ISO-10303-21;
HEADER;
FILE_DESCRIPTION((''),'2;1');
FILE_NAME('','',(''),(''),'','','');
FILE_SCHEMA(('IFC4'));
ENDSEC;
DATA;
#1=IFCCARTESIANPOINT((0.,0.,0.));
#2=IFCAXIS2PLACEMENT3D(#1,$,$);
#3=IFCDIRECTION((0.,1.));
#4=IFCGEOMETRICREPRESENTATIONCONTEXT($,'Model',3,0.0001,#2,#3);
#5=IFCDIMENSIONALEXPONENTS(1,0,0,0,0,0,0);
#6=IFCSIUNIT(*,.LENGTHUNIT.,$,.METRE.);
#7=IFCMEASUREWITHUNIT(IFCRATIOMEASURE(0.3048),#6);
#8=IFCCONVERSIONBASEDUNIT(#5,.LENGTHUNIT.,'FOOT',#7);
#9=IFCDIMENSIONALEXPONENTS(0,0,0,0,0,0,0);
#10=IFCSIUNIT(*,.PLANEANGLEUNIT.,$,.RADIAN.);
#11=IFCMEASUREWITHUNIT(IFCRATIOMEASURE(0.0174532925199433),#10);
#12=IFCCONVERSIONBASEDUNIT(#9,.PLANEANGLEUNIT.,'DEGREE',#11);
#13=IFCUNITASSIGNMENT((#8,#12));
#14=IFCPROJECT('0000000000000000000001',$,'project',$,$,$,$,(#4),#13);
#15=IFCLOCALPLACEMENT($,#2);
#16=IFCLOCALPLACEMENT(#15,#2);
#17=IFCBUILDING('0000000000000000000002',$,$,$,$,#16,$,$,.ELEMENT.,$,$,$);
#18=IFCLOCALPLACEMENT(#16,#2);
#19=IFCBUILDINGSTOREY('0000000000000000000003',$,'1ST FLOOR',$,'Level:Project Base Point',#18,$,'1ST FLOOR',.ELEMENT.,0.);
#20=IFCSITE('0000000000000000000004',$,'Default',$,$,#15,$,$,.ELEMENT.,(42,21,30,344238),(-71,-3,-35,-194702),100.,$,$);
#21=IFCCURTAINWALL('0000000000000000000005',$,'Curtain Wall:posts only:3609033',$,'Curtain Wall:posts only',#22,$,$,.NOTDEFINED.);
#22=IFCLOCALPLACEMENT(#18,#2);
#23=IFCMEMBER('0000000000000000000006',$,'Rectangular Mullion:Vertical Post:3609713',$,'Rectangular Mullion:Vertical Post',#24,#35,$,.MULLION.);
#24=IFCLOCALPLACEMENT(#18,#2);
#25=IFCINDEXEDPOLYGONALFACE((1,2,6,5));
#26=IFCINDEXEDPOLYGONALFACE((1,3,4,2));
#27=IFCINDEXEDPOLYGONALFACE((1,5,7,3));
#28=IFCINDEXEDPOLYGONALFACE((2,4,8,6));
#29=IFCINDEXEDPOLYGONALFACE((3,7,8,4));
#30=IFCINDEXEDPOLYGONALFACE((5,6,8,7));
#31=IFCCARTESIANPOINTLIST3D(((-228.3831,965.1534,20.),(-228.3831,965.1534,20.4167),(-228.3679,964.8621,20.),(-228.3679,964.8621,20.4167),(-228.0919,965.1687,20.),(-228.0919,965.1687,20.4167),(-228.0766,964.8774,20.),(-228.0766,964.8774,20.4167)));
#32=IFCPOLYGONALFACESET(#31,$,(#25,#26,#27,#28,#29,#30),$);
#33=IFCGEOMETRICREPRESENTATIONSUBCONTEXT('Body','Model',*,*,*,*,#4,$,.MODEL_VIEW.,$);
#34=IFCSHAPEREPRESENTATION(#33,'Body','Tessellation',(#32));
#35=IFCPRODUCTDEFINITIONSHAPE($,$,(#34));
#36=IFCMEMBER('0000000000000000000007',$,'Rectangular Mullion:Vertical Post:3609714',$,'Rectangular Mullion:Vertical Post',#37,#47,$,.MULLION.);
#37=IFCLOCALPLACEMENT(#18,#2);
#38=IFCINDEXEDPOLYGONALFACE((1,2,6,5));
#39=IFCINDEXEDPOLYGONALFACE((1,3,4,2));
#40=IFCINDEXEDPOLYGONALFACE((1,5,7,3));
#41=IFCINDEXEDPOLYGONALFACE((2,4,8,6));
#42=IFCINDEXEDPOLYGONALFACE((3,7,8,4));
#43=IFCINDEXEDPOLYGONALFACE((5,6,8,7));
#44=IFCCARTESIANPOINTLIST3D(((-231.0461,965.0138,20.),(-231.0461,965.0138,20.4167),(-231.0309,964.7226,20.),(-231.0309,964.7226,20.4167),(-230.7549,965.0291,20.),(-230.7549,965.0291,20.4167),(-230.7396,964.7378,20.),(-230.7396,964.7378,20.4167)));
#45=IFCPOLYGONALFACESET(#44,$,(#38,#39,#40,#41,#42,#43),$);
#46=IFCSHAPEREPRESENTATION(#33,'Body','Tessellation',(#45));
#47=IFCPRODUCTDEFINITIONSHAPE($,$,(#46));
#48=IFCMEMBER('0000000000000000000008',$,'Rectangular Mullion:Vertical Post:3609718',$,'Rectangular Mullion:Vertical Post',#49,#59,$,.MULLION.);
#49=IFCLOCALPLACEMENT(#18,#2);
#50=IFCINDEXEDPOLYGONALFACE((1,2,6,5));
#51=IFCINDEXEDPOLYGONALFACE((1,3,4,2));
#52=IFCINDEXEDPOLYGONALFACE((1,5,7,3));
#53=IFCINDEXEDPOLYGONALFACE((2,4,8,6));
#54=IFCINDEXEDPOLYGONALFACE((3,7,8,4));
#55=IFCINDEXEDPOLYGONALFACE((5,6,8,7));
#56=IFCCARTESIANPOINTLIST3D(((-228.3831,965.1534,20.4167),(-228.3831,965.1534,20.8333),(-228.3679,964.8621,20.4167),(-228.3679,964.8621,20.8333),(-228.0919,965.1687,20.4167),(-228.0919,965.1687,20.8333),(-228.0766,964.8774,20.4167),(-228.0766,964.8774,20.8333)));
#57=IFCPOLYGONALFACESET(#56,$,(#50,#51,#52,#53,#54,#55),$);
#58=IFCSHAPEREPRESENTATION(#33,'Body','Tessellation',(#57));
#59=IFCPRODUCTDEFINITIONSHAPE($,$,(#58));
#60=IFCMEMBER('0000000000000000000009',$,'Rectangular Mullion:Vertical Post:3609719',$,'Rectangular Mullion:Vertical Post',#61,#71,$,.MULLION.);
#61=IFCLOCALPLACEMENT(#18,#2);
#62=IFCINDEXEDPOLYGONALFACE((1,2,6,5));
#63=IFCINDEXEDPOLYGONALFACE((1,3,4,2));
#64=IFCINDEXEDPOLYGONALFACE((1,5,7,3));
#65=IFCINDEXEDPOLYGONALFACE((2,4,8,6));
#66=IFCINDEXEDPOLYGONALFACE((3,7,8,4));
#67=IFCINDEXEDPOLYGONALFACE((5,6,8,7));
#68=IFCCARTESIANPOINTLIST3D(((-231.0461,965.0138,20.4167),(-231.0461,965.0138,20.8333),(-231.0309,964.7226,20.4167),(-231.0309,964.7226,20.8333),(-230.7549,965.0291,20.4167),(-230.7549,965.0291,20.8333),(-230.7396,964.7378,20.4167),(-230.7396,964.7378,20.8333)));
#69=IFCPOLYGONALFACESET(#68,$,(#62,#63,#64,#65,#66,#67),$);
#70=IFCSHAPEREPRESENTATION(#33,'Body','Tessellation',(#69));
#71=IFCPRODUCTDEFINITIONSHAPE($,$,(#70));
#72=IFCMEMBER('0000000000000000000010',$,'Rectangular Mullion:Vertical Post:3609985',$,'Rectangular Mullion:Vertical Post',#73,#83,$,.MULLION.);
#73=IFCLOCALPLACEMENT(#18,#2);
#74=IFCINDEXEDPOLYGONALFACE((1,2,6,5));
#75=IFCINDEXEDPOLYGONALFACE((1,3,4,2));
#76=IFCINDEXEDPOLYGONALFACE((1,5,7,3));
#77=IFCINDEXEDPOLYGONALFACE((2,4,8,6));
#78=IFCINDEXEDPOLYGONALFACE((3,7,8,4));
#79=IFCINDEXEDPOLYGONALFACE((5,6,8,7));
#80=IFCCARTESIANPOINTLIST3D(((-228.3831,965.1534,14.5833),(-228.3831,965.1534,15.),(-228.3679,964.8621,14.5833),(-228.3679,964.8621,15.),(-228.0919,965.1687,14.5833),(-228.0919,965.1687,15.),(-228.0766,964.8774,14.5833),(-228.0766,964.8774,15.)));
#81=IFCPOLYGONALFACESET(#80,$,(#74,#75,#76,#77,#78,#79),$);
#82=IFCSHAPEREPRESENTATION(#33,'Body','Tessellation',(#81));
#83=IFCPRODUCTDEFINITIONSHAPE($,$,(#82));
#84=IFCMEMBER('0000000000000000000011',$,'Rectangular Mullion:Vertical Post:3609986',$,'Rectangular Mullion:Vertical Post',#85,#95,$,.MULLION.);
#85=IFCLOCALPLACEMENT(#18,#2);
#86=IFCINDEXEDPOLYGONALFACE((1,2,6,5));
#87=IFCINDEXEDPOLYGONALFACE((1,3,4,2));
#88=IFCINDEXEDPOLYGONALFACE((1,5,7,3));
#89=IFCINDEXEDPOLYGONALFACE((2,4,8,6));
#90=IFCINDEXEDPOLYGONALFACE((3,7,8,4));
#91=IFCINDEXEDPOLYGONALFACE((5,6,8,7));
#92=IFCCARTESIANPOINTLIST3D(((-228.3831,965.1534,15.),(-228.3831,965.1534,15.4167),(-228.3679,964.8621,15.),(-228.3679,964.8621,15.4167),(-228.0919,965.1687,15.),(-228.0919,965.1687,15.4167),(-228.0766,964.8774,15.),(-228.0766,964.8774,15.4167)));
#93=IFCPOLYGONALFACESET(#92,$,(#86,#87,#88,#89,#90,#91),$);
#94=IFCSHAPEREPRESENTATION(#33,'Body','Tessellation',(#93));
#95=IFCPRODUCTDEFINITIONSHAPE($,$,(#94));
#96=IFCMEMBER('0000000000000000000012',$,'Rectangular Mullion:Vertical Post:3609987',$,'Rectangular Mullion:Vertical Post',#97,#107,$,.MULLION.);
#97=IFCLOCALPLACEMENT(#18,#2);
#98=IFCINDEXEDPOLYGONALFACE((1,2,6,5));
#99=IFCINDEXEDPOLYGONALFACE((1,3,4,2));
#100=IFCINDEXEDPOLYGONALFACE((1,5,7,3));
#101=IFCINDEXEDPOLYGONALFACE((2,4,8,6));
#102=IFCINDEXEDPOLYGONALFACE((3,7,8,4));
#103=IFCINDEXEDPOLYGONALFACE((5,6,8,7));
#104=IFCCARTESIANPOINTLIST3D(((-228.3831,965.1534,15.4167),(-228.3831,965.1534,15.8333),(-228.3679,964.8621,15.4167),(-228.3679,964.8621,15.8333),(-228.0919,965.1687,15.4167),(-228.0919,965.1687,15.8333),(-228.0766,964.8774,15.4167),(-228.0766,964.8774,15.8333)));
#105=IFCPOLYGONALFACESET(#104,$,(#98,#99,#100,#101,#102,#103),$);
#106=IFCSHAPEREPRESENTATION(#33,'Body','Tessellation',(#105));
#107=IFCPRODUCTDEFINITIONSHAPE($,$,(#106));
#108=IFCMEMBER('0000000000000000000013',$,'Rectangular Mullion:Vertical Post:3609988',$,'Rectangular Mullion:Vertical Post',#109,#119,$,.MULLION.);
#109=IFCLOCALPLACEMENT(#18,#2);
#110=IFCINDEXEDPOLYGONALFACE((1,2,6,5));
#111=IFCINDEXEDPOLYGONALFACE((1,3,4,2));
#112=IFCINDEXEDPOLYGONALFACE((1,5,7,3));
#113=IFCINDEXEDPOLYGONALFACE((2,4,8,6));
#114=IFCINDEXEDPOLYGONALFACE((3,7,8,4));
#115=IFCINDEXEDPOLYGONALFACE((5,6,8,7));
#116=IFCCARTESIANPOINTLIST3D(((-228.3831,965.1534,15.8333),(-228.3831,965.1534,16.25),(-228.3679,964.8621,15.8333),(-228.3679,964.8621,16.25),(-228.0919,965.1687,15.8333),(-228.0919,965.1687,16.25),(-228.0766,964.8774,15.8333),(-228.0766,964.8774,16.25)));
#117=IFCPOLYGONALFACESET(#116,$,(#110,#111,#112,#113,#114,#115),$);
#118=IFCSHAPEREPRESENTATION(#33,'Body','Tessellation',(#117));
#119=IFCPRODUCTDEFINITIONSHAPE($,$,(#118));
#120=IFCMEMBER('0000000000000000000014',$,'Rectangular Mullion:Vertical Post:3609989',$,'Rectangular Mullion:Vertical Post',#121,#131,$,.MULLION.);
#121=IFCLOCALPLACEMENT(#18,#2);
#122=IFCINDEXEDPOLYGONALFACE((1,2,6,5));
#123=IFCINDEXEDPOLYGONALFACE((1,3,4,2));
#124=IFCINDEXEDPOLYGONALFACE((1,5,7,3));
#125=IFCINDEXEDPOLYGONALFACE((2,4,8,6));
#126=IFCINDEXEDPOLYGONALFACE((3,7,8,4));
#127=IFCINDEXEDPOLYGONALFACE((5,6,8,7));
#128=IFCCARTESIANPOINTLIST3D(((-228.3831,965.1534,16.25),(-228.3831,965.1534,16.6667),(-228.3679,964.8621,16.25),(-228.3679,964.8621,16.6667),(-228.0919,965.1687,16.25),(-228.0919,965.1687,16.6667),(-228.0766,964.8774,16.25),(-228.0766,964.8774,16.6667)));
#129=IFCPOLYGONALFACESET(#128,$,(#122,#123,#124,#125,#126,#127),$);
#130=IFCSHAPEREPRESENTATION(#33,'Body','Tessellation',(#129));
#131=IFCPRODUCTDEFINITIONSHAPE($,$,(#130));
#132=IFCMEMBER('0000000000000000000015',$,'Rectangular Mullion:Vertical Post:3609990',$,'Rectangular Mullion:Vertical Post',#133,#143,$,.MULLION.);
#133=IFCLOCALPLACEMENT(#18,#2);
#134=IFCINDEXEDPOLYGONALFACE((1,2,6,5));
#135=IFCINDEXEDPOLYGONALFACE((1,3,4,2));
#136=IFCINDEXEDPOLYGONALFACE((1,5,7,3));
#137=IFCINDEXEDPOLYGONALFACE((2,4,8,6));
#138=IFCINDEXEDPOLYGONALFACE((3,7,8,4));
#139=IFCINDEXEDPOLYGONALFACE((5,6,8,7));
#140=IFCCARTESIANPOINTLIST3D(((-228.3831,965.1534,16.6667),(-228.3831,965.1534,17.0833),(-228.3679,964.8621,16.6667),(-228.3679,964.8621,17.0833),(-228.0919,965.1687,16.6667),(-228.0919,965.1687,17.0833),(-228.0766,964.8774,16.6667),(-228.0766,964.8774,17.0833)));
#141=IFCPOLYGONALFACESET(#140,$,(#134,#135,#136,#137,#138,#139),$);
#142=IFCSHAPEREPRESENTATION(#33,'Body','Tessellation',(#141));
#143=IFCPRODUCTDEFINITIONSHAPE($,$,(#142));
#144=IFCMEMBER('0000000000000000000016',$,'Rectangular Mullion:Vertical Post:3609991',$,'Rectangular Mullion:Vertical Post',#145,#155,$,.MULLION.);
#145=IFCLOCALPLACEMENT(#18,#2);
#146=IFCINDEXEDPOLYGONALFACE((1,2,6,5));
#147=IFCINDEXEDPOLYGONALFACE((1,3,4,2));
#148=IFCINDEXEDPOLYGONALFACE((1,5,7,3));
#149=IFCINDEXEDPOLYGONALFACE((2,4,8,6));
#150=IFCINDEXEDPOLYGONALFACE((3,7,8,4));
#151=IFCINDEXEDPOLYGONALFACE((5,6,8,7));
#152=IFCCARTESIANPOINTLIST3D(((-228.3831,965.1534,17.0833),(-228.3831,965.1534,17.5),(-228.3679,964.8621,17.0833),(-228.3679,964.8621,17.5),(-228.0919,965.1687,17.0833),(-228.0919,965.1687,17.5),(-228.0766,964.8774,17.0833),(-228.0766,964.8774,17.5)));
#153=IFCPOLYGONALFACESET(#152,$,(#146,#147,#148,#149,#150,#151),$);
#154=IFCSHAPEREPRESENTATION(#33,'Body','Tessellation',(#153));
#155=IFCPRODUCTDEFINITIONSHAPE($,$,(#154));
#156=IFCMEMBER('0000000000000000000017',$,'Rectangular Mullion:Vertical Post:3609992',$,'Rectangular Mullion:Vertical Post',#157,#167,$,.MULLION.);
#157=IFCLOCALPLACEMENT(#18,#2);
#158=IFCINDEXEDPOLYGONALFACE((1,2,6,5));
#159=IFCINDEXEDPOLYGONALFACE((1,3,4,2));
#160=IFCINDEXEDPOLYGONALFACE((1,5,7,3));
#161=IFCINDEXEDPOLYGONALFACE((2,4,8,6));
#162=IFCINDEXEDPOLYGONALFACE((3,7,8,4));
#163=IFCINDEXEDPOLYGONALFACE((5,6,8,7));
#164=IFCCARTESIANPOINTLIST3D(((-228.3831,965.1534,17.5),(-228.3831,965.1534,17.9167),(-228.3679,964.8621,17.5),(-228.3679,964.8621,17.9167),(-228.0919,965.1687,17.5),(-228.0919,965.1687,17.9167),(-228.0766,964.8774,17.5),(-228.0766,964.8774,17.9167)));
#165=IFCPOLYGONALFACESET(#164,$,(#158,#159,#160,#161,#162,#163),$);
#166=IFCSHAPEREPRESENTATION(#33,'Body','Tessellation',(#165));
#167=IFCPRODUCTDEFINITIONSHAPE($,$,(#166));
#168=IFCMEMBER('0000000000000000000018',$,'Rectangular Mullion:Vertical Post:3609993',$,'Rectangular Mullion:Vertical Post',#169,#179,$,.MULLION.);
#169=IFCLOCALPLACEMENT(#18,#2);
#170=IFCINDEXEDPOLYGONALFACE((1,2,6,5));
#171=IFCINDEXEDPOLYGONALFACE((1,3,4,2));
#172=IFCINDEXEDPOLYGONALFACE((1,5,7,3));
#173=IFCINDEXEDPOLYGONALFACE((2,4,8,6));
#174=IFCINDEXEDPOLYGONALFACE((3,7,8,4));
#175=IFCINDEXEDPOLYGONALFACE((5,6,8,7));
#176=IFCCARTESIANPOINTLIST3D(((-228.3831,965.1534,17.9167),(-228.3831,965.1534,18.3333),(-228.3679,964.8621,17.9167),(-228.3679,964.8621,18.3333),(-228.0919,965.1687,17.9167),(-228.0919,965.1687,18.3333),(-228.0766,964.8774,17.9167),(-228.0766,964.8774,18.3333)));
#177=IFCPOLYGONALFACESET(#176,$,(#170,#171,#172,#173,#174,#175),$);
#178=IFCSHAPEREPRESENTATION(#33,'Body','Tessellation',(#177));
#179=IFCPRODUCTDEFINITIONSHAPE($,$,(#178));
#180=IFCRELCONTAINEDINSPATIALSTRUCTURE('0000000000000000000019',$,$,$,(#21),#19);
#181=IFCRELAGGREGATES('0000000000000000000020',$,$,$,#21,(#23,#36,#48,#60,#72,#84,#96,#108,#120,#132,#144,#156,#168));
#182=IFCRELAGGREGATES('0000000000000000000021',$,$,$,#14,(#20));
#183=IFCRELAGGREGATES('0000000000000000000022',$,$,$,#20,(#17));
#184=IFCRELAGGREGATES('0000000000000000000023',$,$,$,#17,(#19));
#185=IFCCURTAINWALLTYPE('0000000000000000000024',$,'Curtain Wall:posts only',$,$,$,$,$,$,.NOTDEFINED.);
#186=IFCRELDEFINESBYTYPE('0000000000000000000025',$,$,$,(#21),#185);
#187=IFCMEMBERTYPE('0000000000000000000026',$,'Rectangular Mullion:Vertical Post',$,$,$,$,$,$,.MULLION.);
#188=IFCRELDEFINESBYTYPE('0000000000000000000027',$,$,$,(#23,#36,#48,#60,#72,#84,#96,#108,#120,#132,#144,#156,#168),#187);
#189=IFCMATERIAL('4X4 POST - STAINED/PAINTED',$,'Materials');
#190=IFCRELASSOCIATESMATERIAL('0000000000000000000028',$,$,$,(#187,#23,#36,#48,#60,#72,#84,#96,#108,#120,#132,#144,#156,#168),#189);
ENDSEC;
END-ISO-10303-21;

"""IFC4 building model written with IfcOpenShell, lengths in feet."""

from ifc_helpers import new_model, entity, si_unit, converted_unit, direction, frame, origin, origin_2d_with_axis, place, context, subcontext, project, spatial, rectangle, extrude, source, transform, mapped, material, material_profile, profile_set, profile_usage, type_object, type_shapes, element, aggregate, save


model = new_model("IFC4")

# Units and contexts
model_context = context("Model", 3, precision=0.0001, world=origin(), true_north=direction((0.0, 1.0)))
body_context = subcontext(model_context, "Body", "Model", "MODEL_VIEW")
ifc_project = project(units=[converted_unit("LENGTHUNIT", "FOOT", entity("IfcRatioMeasure", 0.3048), si_unit("LENGTHUNIT", "METRE"), dimensions=[1, 0, 0, 0, 0, 0, 0]), converted_unit("PLANEANGLEUNIT", "DEGREE", entity("IfcRatioMeasure", 0.0174532925199433), si_unit("PLANEANGLEUNIT", "RADIAN"), dimensions=[0, 0, 0, 0, 0, 0, 0])], contexts=[model_context])

# Site, building, storey
site_placement = place(None, origin())
site = spatial("IfcSite", under=ifc_project, at=site_placement, Name="Default", CompositionType="ELEMENT", RefLatitude=(42, 21, 30, 344238), RefLongitude=(-71, -3, -35, -194702), RefElevation=100.0)
building_placement = place(site_placement, origin())
building = spatial("IfcBuilding", under=site, at=building_placement, CompositionType="ELEMENT")
storey_placement = place(building_placement, origin())
storey = spatial("IfcBuildingStorey", under=building, at=storey_placement, Name="1ST FLOOR", ObjectType="Level:Project Base Point", LongName="1ST FLOOR", CompositionType="ELEMENT", Elevation=0.0)

# Curtain wall, members
curtain_wall_type_1 = type_object("IfcCurtainWallType", Name="Curtain Wall:posts only", PredefinedType="NOTDEFINED")
curtain_wall_1_placement = place(storey_placement, origin())
curtain_wall_1 = element("IfcCurtainWall", 1, at=curtain_wall_1_placement, inside=storey, type_object=curtain_wall_type_1, Name="Curtain Wall:posts only:3609033", ObjectType="Curtain Wall:posts only", PredefinedType="NOTDEFINED")
ifc_material_1 = material(Name="4X4 POST - STAINED/PAINTED", Category="Materials")
ifc_material_profile_1 = material_profile(ifc_material_1, rectangle(XDim=0.2917, YDim=0.2917, at=origin_2d_with_axis()), Name="Vertical Post")
ifc_profile_set_1 = profile_set([ifc_material_profile_1], Name="Vertical Post")
ifc_profile_usage_1 = profile_usage(ifc_profile_set_1)
member_type_1 = type_object("IfcMemberType", Name="Rectangular Mullion:Vertical Post", PredefinedType="MULLION", material=ifc_profile_set_1)
shared_shape_1 = source(origin(), body_context, "Body", "SweptSolid", [
    extrude(rectangle(XDim=0.2917, YDim=0.2917, at=origin_2d_with_axis()), frame((0.0, -0.2083, -0.4167), z_axis=(0.0, 0.0, 1.0), x_axis=(0.0, -1.0, 0.0)), (0.0, 0.0, 1.0), 0.4167),
])
type_shapes(member_type_1, [shared_shape_1])
member_1_placement = place(storey_placement, frame((-228.2408, 965.2235, 20.0), z_axis=(0.0, 0.0, -1.0), x_axis=(-0.99863, -0.052336, 0.0)))
member_1 = element("IfcMember", 2, at=member_1_placement, type_object=member_type_1, material=ifc_profile_usage_1, Name="Rectangular Mullion:Vertical Post:3609713", ObjectType="Rectangular Mullion:Vertical Post", PredefinedType="MULLION", context=body_context, shape_type="MappedRepresentation", body=[
    mapped(shared_shape_1, transform((0.0, 0.0, 0.0), scale=1.0)),
])
ifc_profile_usage_2 = profile_usage(ifc_profile_set_1)
member_2_placement = place(storey_placement, frame((-230.9038, 965.0839, 20.0), z_axis=(0.0, 0.0, -1.0), x_axis=(-0.99863, -0.052336, 0.0)))
member_2 = element("IfcMember", 3, at=member_2_placement, type_object=member_type_1, material=ifc_profile_usage_2, Name="Rectangular Mullion:Vertical Post:3609714", ObjectType="Rectangular Mullion:Vertical Post", PredefinedType="MULLION", context=body_context, shape_type="MappedRepresentation", body=[
    mapped(shared_shape_1, transform((0.0, 0.0, 0.0), scale=1.0)),
])
ifc_profile_usage_3 = profile_usage(ifc_profile_set_1)
member_3_placement = place(storey_placement, frame((-228.2408, 965.2235, 20.4167), z_axis=(0.0, 0.0, -1.0), x_axis=(-0.99863, -0.052336, 0.0)))
member_3 = element("IfcMember", 4, at=member_3_placement, type_object=member_type_1, material=ifc_profile_usage_3, Name="Rectangular Mullion:Vertical Post:3609718", ObjectType="Rectangular Mullion:Vertical Post", PredefinedType="MULLION", context=body_context, shape_type="MappedRepresentation", body=[
    mapped(shared_shape_1, transform((0.0, 0.0, 0.0), scale=1.0)),
])
ifc_profile_usage_4 = profile_usage(ifc_profile_set_1)
member_4_placement = place(storey_placement, frame((-230.9038, 965.0839, 20.4167), z_axis=(0.0, 0.0, -1.0), x_axis=(-0.99863, -0.052336, 0.0)))
member_4 = element("IfcMember", 5, at=member_4_placement, type_object=member_type_1, material=ifc_profile_usage_4, Name="Rectangular Mullion:Vertical Post:3609719", ObjectType="Rectangular Mullion:Vertical Post", PredefinedType="MULLION", context=body_context, shape_type="MappedRepresentation", body=[
    mapped(shared_shape_1, transform((0.0, 0.0, 0.0), scale=1.0)),
])
ifc_profile_usage_5 = profile_usage(ifc_profile_set_1)
member_5_placement = place(storey_placement, frame((-228.2408, 965.2235, 14.5833), z_axis=(0.0, 0.0, -1.0), x_axis=(-0.99863, -0.052336, 0.0)))
member_5 = element("IfcMember", 6, at=member_5_placement, type_object=member_type_1, material=ifc_profile_usage_5, Name="Rectangular Mullion:Vertical Post:3609985", ObjectType="Rectangular Mullion:Vertical Post", PredefinedType="MULLION", context=body_context, shape_type="MappedRepresentation", body=[
    mapped(shared_shape_1, transform((0.0, 0.0, 0.0), scale=1.0)),
])
ifc_profile_usage_6 = profile_usage(ifc_profile_set_1)
member_6_placement = place(storey_placement, frame((-228.2408, 965.2235, 15.0), z_axis=(0.0, 0.0, -1.0), x_axis=(-0.99863, -0.052336, 0.0)))
member_6 = element("IfcMember", 7, at=member_6_placement, type_object=member_type_1, material=ifc_profile_usage_6, Name="Rectangular Mullion:Vertical Post:3609986", ObjectType="Rectangular Mullion:Vertical Post", PredefinedType="MULLION", context=body_context, shape_type="MappedRepresentation", body=[
    mapped(shared_shape_1, transform((0.0, 0.0, 0.0), scale=1.0)),
])
ifc_profile_usage_7 = profile_usage(ifc_profile_set_1)
member_7_placement = place(storey_placement, frame((-228.2408, 965.2235, 15.4167), z_axis=(0.0, 0.0, -1.0), x_axis=(-0.99863, -0.052336, 0.0)))
member_7 = element("IfcMember", 8, at=member_7_placement, type_object=member_type_1, material=ifc_profile_usage_7, Name="Rectangular Mullion:Vertical Post:3609987", ObjectType="Rectangular Mullion:Vertical Post", PredefinedType="MULLION", context=body_context, shape_type="MappedRepresentation", body=[
    mapped(shared_shape_1, transform((0.0, 0.0, 0.0), scale=1.0)),
])
ifc_profile_usage_8 = profile_usage(ifc_profile_set_1)
member_8_placement = place(storey_placement, frame((-228.2408, 965.2235, 15.8333), z_axis=(0.0, 0.0, -1.0), x_axis=(-0.99863, -0.052336, 0.0)))
member_8 = element("IfcMember", 9, at=member_8_placement, type_object=member_type_1, material=ifc_profile_usage_8, Name="Rectangular Mullion:Vertical Post:3609988", ObjectType="Rectangular Mullion:Vertical Post", PredefinedType="MULLION", context=body_context, shape_type="MappedRepresentation", body=[
    mapped(shared_shape_1, transform((0.0, 0.0, 0.0), scale=1.0)),
])
ifc_profile_usage_9 = profile_usage(ifc_profile_set_1)
member_9_placement = place(storey_placement, frame((-228.2408, 965.2235, 16.25), z_axis=(0.0, 0.0, -1.0), x_axis=(-0.99863, -0.052336, 0.0)))
member_9 = element("IfcMember", 10, at=member_9_placement, type_object=member_type_1, material=ifc_profile_usage_9, Name="Rectangular Mullion:Vertical Post:3609989", ObjectType="Rectangular Mullion:Vertical Post", PredefinedType="MULLION", context=body_context, shape_type="MappedRepresentation", body=[
    mapped(shared_shape_1, transform((0.0, 0.0, 0.0), scale=1.0)),
])
ifc_profile_usage_10 = profile_usage(ifc_profile_set_1)
member_10_placement = place(storey_placement, frame((-228.2408, 965.2235, 16.6667), z_axis=(0.0, 0.0, -1.0), x_axis=(-0.99863, -0.052336, 0.0)))
member_10 = element("IfcMember", 11, at=member_10_placement, type_object=member_type_1, material=ifc_profile_usage_10, Name="Rectangular Mullion:Vertical Post:3609990", ObjectType="Rectangular Mullion:Vertical Post", PredefinedType="MULLION", context=body_context, shape_type="MappedRepresentation", body=[
    mapped(shared_shape_1, transform((0.0, 0.0, 0.0), scale=1.0)),
])
ifc_profile_usage_11 = profile_usage(ifc_profile_set_1)
member_11_placement = place(storey_placement, frame((-228.2408, 965.2235, 17.0833), z_axis=(0.0, 0.0, -1.0), x_axis=(-0.99863, -0.052336, 0.0)))
member_11 = element("IfcMember", 12, at=member_11_placement, type_object=member_type_1, material=ifc_profile_usage_11, Name="Rectangular Mullion:Vertical Post:3609991", ObjectType="Rectangular Mullion:Vertical Post", PredefinedType="MULLION", context=body_context, shape_type="MappedRepresentation", body=[
    mapped(shared_shape_1, transform((0.0, 0.0, 0.0), scale=1.0)),
])
ifc_profile_usage_12 = profile_usage(ifc_profile_set_1)
member_12_placement = place(storey_placement, frame((-228.2408, 965.2235, 17.5), z_axis=(0.0, 0.0, -1.0), x_axis=(-0.99863, -0.052336, 0.0)))
member_12 = element("IfcMember", 13, at=member_12_placement, type_object=member_type_1, material=ifc_profile_usage_12, Name="Rectangular Mullion:Vertical Post:3609992", ObjectType="Rectangular Mullion:Vertical Post", PredefinedType="MULLION", context=body_context, shape_type="MappedRepresentation", body=[
    mapped(shared_shape_1, transform((0.0, 0.0, 0.0), scale=1.0)),
])
ifc_profile_usage_13 = profile_usage(ifc_profile_set_1)
member_13_placement = place(storey_placement, frame((-228.2408, 965.2235, 17.9167), z_axis=(0.0, 0.0, -1.0), x_axis=(-0.99863, -0.052336, 0.0)))
member_13 = element("IfcMember", 14, at=member_13_placement, type_object=member_type_1, material=ifc_profile_usage_13, Name="Rectangular Mullion:Vertical Post:3609993", ObjectType="Rectangular Mullion:Vertical Post", PredefinedType="MULLION", context=body_context, shape_type="MappedRepresentation", body=[
    mapped(shared_shape_1, transform((0.0, 0.0, 0.0), scale=1.0)),
])
aggregate(curtain_wall_1, [member_1, member_2, member_3, member_4, member_5, member_6, member_7, member_8, member_9, member_10, member_11, member_12, member_13])

save(model, "model.ifc")
